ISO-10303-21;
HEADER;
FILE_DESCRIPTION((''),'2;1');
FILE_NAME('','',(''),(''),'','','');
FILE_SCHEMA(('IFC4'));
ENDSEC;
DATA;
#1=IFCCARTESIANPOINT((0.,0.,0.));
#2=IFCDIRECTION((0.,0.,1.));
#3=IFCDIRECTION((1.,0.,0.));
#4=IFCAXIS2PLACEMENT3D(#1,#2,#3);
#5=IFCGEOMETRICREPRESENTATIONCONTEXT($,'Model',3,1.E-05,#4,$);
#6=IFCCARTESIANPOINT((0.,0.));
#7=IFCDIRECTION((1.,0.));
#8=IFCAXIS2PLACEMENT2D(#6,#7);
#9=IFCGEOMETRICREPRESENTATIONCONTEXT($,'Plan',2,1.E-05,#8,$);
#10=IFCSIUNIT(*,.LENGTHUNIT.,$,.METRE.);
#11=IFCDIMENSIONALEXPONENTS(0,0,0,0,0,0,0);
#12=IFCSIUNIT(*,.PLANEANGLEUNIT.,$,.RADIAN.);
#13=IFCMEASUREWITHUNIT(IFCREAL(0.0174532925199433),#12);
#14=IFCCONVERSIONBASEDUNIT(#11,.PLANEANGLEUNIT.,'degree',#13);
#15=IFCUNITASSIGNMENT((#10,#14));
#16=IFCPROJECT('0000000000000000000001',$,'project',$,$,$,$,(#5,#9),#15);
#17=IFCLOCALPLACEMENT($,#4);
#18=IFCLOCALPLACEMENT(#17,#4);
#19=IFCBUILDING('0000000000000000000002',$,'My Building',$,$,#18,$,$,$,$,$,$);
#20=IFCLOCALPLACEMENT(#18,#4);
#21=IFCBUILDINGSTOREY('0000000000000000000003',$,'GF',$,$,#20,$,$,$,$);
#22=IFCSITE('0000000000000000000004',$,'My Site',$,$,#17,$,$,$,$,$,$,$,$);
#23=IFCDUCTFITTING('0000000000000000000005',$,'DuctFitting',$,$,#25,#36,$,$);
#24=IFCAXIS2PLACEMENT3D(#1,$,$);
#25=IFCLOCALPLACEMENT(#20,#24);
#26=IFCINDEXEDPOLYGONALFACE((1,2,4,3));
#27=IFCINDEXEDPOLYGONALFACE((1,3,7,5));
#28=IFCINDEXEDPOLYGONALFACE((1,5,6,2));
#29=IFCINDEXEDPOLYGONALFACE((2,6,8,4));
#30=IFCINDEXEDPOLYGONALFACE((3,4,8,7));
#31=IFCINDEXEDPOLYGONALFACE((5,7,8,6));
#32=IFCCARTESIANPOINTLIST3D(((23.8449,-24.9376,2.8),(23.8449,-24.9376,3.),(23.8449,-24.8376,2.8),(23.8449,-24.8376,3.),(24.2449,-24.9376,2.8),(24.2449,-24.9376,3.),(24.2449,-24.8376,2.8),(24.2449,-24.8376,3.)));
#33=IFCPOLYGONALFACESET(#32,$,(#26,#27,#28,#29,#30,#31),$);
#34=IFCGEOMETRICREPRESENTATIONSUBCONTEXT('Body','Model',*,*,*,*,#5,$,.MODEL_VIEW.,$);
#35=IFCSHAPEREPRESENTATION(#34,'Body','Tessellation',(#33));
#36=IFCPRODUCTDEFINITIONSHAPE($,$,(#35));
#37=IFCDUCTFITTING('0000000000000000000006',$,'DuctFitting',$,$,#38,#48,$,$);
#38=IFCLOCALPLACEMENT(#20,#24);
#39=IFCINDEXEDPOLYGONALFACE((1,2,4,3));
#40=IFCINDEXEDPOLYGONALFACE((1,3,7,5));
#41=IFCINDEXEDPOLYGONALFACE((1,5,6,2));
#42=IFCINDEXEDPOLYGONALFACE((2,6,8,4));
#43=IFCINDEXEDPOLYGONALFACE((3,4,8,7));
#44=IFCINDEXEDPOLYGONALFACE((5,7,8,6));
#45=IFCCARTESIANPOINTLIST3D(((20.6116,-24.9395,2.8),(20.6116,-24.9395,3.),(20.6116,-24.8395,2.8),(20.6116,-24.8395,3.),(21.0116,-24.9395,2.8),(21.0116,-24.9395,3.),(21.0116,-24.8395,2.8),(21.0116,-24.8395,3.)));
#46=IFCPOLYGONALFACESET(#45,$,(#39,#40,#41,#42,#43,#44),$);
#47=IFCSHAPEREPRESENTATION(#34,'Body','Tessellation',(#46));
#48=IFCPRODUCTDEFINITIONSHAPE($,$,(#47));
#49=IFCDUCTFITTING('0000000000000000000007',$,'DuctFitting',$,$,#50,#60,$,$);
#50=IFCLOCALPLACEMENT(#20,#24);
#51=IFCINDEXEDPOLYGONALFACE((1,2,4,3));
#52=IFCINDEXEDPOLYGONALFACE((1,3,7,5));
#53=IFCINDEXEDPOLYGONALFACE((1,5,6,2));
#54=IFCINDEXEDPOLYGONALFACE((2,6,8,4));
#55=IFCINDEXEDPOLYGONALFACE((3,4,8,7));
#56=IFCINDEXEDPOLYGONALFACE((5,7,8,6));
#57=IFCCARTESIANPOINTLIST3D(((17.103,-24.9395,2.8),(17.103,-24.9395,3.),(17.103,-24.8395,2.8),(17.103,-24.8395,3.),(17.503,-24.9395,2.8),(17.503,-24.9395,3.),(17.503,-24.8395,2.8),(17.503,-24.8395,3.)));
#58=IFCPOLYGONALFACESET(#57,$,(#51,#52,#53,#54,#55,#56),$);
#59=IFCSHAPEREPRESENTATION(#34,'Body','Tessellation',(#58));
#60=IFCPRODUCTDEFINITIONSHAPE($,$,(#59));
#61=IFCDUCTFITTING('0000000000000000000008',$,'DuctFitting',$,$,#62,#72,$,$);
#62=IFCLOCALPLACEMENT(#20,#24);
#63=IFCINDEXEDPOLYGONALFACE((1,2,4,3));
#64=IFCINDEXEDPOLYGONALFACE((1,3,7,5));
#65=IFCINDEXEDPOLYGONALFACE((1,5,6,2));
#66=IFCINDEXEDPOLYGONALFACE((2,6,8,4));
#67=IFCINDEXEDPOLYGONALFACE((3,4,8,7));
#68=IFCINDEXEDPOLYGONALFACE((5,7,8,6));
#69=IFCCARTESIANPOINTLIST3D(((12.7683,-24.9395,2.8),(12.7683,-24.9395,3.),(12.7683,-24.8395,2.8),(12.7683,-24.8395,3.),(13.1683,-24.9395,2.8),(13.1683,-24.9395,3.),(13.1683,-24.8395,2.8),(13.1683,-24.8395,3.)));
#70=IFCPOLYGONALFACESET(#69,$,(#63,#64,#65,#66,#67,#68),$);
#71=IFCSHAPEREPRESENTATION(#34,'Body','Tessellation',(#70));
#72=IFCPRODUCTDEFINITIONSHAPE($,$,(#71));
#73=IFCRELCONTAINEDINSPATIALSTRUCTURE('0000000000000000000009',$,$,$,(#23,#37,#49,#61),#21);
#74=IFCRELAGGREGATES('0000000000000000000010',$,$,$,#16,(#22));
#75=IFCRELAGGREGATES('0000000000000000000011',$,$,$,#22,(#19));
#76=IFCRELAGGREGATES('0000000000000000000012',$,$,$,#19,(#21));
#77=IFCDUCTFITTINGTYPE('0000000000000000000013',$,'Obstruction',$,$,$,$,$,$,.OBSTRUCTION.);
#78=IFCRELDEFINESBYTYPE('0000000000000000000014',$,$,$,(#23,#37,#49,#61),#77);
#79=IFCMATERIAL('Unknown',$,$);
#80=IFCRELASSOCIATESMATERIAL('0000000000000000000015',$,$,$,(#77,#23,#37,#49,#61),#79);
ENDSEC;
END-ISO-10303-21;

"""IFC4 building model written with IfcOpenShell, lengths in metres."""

from ifc_helpers import new_model, entity, si_unit, converted_unit, frame, origin_with_axes, origin_2d_with_axis, place, context, subcontext, project, spatial, rectangle, extrude, material, material_profile, profile_set, profile_usage, type_object, element, save


model = new_model("IFC4")

# Units and contexts
model_context = context("Model", 3, precision=1e-05, world=origin_with_axes())
plan_context = context("Plan", 2, precision=1e-05, world=origin_2d_with_axis())
body_context_1 = subcontext(model_context, "Body", "Model", "MODEL_VIEW")
ifc_project = project(units=[si_unit("LENGTHUNIT", "METRE"), converted_unit("PLANEANGLEUNIT", "degree", entity("IfcReal", 0.0174532925199433), si_unit("PLANEANGLEUNIT", "RADIAN"), dimensions=[0, 0, 0, 0, 0, 0, 0])], contexts=[model_context, plan_context])

# Site, building, storey
site_placement = place(None, origin_with_axes())
site = spatial("IfcSite", under=ifc_project, at=site_placement, Name="My Site")
building_placement = place(site_placement, origin_with_axes())
building = spatial("IfcBuilding", under=site, at=building_placement, Name="My Building")
storey_placement = place(building_placement, origin_with_axes())
storey = spatial("IfcBuildingStorey", under=building, at=storey_placement, Name="GF")

# Shared definitions
ifc_material = material(Name="Unknown")

# Duct fittings
ifc_material_profile = material_profile(ifc_material, rectangle(XDim=0.4, YDim=0.2))
ifc_profile_set = profile_set([ifc_material_profile])
ifc_profile_usage_1 = profile_usage(ifc_profile_set, cardinal=5)
duct_fitting_type = type_object("IfcDuctFittingType", Name="Obstruction", PredefinedType="OBSTRUCTION", material=ifc_profile_set)
duct_fitting_1_placement = place(storey_placement, frame((24.0449, -24.8376, 2.9), z_axis=(0.0, -1.0, 0.0), x_axis=(1.0, 0.0, 0.0)))
element("IfcDuctFitting", 1, at=duct_fitting_1_placement, inside=storey, type_object=duct_fitting_type, material=ifc_profile_usage_1, Name="DuctFitting", context=body_context_1, shape_type="SweptSolid", body=[
    extrude(rectangle(XDim=0.4, YDim=0.2), origin_with_axes(), (0.0, 0.0, 1.0), 0.1),
])
ifc_profile_usage_2 = profile_usage(ifc_profile_set, cardinal=5)
duct_fitting_2_placement = place(storey_placement, frame((20.8116, -24.8395, 2.9), z_axis=(0.0, -1.0, 0.0), x_axis=(1.0, 0.0, 0.0)))
element("IfcDuctFitting", 2, at=duct_fitting_2_placement, inside=storey, type_object=duct_fitting_type, material=ifc_profile_usage_2, Name="DuctFitting", context=body_context_1, shape_type="SweptSolid", body=[
    extrude(rectangle(XDim=0.4, YDim=0.2), origin_with_axes(), (0.0, 0.0, 1.0), 0.1),
])
ifc_profile_usage_3 = profile_usage(ifc_profile_set, cardinal=5)
duct_fitting_3_placement = place(storey_placement, frame((17.303, -24.8395, 2.9), z_axis=(0.0, -1.0, 0.0), x_axis=(1.0, 0.0, 0.0)))
element("IfcDuctFitting", 3, at=duct_fitting_3_placement, inside=storey, type_object=duct_fitting_type, material=ifc_profile_usage_3, Name="DuctFitting", context=body_context_1, shape_type="SweptSolid", body=[
    extrude(rectangle(XDim=0.4, YDim=0.2), origin_with_axes(), (0.0, 0.0, 1.0), 0.1),
])
ifc_profile_usage_4 = profile_usage(ifc_profile_set, cardinal=5)
duct_fitting_4_placement = place(storey_placement, frame((12.9683, -24.8395, 2.9), z_axis=(0.0, -1.0, 0.0), x_axis=(1.0, 0.0, 0.0)))
element("IfcDuctFitting", 4, at=duct_fitting_4_placement, inside=storey, type_object=duct_fitting_type, material=ifc_profile_usage_4, Name="DuctFitting", context=body_context_1, shape_type="SweptSolid", body=[
    extrude(rectangle(XDim=0.4, YDim=0.2), origin_with_axes(), (0.0, 0.0, 1.0), 0.1),
])

save(model, "model.ifc")
